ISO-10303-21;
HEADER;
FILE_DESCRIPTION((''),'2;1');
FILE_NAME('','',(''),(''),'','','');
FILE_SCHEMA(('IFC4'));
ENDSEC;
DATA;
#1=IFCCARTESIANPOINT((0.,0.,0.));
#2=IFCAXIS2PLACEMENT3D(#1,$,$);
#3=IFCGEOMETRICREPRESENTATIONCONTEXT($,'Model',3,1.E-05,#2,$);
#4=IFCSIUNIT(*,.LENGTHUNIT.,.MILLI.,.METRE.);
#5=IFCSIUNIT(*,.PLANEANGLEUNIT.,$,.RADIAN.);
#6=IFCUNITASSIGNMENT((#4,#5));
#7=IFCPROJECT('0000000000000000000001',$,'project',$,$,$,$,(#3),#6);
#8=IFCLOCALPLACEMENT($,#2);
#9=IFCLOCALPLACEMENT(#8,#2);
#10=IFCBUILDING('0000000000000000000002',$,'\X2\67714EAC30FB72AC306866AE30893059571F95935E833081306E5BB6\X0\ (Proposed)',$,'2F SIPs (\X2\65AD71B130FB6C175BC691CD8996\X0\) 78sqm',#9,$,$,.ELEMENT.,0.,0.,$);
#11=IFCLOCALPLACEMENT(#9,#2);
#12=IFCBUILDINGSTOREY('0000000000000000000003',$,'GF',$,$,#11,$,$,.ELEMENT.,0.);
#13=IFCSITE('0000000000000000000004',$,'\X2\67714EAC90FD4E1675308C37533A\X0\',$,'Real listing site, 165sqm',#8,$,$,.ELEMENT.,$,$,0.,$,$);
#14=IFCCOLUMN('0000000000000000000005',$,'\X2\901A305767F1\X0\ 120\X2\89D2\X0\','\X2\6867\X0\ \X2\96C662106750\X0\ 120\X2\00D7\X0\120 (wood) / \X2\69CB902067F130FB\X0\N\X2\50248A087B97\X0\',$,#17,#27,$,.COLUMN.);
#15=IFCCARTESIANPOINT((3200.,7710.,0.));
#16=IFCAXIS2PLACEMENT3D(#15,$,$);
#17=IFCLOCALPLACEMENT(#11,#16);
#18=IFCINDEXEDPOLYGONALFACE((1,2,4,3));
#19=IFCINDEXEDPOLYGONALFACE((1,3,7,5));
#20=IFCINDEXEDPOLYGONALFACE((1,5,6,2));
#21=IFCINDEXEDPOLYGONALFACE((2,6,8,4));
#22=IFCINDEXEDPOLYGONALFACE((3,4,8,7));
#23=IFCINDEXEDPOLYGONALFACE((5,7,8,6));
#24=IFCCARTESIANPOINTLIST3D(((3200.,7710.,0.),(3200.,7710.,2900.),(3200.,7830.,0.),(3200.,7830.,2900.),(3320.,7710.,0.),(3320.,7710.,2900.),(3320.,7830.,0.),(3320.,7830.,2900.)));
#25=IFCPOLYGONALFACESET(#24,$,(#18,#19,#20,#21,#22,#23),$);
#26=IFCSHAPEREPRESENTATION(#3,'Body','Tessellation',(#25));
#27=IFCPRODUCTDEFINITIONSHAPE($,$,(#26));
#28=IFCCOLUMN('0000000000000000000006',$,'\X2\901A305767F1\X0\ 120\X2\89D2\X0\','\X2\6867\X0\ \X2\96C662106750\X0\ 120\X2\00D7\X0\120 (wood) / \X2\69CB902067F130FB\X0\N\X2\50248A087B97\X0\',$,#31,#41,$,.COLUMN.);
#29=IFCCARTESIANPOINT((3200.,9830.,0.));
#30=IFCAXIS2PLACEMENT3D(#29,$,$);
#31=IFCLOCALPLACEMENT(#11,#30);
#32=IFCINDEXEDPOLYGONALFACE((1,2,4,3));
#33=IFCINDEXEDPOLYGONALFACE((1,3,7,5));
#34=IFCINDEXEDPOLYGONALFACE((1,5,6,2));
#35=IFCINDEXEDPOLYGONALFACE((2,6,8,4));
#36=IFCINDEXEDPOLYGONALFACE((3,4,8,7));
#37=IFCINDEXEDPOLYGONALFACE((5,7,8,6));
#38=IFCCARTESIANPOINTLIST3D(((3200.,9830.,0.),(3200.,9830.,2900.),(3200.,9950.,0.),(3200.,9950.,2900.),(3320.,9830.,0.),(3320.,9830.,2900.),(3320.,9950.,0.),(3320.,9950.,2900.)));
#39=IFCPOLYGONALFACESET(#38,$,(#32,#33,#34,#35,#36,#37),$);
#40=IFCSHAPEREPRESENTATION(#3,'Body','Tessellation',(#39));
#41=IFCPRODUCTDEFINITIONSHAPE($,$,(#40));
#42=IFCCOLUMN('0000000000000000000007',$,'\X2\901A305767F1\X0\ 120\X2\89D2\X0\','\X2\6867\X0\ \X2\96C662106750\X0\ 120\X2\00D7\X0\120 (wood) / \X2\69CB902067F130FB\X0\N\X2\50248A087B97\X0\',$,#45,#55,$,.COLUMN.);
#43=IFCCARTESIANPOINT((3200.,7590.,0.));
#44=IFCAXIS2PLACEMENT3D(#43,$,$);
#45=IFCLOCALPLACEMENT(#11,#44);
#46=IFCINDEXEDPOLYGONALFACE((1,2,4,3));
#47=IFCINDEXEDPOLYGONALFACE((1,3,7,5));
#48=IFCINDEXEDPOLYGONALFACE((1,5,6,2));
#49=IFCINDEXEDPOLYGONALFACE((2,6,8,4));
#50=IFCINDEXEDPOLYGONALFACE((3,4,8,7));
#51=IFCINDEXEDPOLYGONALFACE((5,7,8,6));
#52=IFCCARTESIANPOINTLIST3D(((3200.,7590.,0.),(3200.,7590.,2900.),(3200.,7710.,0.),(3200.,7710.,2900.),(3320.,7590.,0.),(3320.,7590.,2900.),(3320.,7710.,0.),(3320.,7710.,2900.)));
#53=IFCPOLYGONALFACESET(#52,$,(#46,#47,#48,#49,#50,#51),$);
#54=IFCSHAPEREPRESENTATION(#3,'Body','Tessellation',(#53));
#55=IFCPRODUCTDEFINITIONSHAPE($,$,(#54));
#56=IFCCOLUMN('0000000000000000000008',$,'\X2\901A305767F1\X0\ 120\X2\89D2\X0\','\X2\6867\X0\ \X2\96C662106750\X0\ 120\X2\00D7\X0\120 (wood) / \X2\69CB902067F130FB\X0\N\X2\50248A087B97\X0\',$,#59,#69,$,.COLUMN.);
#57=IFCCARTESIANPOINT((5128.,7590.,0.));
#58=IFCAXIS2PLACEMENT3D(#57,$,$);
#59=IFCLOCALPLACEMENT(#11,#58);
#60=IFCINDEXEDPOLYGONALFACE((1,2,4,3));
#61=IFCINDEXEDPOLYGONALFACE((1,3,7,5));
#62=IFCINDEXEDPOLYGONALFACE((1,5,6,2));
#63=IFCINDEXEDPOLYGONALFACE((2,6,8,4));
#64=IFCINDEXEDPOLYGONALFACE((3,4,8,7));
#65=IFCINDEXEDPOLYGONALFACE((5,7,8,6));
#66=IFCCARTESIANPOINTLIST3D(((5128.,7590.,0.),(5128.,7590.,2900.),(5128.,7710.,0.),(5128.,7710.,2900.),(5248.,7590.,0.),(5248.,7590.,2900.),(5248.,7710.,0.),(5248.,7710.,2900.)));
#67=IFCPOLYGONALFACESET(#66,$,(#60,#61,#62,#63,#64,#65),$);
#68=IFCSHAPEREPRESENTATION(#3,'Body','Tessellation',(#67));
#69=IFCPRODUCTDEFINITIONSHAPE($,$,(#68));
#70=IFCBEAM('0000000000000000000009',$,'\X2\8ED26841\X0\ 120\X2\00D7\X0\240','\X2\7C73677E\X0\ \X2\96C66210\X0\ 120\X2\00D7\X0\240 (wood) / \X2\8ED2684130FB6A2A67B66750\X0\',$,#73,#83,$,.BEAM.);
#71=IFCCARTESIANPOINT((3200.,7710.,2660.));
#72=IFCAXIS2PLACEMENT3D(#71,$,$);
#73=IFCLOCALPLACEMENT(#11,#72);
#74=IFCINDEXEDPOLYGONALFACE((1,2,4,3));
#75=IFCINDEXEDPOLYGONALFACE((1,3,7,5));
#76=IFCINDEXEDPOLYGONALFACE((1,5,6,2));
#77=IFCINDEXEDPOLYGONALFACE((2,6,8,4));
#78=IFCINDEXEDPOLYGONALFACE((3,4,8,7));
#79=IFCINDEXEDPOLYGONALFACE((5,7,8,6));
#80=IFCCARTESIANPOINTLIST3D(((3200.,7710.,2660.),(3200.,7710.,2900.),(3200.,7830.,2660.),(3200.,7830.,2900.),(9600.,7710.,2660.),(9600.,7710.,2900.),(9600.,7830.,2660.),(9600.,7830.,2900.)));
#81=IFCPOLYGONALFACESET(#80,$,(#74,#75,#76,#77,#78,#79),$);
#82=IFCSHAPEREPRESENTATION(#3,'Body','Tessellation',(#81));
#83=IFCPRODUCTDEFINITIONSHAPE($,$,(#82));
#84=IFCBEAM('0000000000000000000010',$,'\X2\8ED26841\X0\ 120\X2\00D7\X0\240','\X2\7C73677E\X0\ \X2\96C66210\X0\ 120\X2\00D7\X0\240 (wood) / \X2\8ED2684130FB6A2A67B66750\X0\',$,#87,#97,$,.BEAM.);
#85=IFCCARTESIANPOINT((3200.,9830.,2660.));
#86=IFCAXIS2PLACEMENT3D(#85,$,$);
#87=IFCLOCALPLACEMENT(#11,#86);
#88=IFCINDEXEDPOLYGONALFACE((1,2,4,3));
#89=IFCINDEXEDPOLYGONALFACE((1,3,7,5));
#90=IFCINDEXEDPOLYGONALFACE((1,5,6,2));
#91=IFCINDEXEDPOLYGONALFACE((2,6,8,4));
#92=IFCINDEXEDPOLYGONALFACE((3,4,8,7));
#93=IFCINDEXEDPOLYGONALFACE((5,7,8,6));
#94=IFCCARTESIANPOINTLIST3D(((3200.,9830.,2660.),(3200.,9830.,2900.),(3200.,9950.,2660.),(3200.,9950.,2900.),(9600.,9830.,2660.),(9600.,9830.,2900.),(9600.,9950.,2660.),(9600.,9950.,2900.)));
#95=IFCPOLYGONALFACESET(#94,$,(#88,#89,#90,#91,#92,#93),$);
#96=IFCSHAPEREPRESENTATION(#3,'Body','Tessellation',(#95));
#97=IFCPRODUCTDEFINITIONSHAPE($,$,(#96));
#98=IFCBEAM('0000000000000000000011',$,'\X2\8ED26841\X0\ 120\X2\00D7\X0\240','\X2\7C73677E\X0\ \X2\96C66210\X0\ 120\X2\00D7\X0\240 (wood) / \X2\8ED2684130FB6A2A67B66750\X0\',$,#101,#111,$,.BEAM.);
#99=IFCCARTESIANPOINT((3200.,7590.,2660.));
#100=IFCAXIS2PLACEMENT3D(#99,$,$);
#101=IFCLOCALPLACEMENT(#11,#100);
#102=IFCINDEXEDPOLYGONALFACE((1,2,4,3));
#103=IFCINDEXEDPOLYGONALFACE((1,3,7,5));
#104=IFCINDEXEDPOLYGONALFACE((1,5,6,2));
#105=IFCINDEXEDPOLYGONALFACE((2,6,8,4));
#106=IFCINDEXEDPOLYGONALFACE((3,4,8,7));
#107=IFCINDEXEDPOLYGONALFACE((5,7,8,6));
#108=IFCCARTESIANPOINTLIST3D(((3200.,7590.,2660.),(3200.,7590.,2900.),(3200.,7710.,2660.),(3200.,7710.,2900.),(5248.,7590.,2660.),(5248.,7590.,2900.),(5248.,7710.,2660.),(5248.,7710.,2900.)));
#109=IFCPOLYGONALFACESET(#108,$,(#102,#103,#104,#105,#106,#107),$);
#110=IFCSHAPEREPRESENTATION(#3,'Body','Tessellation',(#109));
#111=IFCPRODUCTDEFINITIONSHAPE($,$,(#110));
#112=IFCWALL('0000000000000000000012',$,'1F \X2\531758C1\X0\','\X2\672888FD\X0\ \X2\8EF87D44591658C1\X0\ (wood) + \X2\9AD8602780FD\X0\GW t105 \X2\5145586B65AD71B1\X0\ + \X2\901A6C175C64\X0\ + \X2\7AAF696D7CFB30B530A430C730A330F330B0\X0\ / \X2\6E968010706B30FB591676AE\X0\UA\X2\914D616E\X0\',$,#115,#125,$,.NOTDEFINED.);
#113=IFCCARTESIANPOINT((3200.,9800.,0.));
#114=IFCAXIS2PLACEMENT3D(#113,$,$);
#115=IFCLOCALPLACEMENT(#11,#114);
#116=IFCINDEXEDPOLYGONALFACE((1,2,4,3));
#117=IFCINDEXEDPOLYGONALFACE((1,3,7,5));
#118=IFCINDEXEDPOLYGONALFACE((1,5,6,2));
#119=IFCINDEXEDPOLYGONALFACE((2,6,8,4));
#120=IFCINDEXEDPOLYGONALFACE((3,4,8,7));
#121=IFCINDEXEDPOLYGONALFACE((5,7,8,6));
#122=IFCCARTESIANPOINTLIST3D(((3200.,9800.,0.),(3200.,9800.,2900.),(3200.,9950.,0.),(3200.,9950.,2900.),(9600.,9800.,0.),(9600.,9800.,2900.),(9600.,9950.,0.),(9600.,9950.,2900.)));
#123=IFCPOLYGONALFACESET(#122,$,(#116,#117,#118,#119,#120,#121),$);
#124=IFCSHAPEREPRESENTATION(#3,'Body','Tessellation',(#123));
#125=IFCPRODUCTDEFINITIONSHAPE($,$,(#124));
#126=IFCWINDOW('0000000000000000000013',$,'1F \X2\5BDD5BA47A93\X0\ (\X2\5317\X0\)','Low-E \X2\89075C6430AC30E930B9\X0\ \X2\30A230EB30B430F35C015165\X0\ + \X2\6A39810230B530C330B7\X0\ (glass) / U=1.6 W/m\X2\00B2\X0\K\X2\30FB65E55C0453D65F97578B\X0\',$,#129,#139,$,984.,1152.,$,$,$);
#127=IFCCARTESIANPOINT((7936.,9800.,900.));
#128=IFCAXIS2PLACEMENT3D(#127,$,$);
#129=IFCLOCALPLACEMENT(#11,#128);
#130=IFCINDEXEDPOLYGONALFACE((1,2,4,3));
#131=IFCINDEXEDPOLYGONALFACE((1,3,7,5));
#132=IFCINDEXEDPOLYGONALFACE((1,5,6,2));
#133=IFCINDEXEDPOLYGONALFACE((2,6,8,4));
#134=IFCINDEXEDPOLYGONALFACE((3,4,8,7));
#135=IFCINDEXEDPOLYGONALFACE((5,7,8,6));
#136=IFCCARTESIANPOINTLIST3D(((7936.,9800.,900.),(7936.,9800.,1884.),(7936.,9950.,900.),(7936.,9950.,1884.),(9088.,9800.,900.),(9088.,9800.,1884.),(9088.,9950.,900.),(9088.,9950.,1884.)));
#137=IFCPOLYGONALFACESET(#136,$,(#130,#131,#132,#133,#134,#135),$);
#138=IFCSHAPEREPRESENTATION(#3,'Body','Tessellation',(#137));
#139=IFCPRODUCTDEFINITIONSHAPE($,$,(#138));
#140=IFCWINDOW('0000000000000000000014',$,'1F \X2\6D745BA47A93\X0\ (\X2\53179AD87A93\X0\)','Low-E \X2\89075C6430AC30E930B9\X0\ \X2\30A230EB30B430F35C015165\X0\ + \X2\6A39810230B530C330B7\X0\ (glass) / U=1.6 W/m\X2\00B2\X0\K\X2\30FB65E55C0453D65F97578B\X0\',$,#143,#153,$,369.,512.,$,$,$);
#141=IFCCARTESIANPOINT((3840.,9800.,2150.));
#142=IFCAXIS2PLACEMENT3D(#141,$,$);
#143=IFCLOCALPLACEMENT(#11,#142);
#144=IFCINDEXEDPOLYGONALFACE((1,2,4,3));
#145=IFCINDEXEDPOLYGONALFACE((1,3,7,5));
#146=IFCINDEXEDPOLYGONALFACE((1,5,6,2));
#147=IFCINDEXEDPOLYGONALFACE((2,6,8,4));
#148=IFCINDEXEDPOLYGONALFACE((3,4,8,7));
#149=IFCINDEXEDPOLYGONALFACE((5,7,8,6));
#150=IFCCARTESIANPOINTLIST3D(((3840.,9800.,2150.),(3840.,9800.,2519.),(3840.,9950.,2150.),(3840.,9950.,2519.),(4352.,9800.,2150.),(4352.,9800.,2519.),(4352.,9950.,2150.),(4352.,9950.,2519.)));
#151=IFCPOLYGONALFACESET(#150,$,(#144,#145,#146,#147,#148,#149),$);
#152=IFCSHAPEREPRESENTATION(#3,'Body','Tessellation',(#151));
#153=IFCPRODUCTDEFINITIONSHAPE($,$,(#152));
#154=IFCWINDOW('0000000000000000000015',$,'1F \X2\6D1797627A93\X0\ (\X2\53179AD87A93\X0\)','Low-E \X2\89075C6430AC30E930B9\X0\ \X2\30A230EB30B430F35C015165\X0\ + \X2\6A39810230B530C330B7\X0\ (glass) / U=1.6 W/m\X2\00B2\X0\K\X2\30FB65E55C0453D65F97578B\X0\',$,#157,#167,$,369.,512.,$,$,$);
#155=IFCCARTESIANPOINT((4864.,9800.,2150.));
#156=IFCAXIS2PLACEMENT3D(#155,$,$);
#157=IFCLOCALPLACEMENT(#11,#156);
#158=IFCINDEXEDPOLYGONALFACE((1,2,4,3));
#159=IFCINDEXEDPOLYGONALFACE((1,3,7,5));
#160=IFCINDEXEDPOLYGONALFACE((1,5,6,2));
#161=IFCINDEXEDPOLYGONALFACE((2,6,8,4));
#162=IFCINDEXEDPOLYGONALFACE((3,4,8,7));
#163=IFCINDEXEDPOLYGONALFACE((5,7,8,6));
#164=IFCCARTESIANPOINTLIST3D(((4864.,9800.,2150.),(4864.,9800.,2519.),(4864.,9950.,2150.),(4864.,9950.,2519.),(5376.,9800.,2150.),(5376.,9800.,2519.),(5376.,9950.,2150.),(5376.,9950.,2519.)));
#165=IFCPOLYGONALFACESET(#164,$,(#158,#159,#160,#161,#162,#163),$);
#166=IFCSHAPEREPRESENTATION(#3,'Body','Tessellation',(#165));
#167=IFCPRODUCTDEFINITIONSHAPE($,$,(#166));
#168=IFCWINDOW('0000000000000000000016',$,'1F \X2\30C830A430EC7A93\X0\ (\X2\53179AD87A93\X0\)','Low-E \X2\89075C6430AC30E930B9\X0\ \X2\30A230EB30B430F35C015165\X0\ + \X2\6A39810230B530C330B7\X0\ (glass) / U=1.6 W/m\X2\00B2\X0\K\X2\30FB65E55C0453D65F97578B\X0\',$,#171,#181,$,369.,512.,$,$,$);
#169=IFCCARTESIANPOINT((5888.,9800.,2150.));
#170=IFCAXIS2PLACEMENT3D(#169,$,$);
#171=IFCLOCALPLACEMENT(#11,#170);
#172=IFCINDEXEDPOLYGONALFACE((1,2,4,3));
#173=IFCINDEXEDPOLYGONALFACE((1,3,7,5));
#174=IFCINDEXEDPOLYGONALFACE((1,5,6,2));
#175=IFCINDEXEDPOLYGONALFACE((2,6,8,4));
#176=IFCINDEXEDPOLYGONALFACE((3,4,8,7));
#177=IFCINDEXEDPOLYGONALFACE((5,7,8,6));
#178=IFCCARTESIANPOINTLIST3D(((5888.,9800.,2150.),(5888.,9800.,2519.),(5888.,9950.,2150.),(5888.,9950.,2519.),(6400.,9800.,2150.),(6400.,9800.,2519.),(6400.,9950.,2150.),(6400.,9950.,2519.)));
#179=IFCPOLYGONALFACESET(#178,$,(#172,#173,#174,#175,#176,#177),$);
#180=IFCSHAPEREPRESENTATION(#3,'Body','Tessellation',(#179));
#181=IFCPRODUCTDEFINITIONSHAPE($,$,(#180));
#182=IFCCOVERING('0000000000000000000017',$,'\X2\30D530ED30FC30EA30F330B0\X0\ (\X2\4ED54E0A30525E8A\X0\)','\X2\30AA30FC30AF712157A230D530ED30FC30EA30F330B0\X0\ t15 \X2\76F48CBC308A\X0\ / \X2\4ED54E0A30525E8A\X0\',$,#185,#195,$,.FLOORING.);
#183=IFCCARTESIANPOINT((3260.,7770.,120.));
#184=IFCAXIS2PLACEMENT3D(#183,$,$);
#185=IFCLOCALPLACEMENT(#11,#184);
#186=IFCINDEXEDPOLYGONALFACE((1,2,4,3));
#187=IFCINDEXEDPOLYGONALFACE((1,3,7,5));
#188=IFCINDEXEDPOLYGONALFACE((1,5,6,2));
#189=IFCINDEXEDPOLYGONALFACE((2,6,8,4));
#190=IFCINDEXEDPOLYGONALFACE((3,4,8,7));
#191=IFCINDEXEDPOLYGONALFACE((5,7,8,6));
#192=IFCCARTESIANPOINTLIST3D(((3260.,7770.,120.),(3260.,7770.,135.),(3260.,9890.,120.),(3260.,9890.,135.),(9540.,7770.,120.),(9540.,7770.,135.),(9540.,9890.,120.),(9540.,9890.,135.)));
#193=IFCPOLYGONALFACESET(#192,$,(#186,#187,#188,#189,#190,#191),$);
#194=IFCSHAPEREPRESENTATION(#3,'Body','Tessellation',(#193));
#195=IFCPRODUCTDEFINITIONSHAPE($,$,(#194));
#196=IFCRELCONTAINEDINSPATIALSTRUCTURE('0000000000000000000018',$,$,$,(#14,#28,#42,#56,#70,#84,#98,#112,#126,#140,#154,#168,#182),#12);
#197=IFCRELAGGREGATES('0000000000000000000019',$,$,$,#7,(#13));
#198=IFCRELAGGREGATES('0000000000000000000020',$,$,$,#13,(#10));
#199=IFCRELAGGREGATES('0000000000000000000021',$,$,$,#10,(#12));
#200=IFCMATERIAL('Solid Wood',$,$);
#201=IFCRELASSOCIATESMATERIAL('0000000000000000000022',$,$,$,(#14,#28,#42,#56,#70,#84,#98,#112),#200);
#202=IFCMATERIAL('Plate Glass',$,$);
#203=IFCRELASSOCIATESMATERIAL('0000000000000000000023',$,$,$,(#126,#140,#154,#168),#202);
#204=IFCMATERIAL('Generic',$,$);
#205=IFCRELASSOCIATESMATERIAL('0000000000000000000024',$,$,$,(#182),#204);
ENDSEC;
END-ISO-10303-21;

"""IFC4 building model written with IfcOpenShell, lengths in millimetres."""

from ifc_helpers import new_model, si_unit, frame, frame_2d, origin, place, context, project, spatial, rectangle, extrude, material, element, fill, save


model = new_model("IFC4")

# Units and contexts
model_context = context("Model", 3, precision=1e-05, world=origin())
ifc_project = project(units=[si_unit("LENGTHUNIT", "METRE", prefix="MILLI"), si_unit("PLANEANGLEUNIT", "RADIAN")], contexts=[model_context])

# Site, building, storey
site_placement = place(None, origin())
site = spatial("IfcSite", under=ifc_project, at=site_placement, Name="東京都世田谷区", ObjectType="Real listing site, 165sqm", CompositionType="ELEMENT", RefElevation=0.0)
building_placement = place(site_placement, origin())
building = spatial("IfcBuilding", under=site, at=building_placement, Name="東京・犬と暮らす土間広めの家 (Proposed)", ObjectType="2F SIPs (断熱・気密重視) 78sqm", CompositionType="ELEMENT", ElevationOfRefHeight=0.0, ElevationOfTerrain=0.0)
storey_placement = place(building_placement, origin())
storey = spatial("IfcBuildingStorey", under=building, at=storey_placement, Name="GF", CompositionType="ELEMENT", Elevation=0.0)

# Columns
ifc_material_1 = material(Name="Solid Wood")
column_1_placement = place(storey_placement, frame((3200.0, 7710.0, 0.0)))
element("IfcColumn", 1, at=column_1_placement, inside=storey, material=ifc_material_1, Name="通し柱 120角", Description="桧 集成材 120×120 (wood) / 構造柱・N値計算", PredefinedType="COLUMN", context=model_context, shape_type="SweptSolid", body=[
    extrude(rectangle(XDim=120.0, YDim=120.0, at=frame_2d((60.0, 60.0))), frame((3200.0, 7710.0, 0.0)), (0.0, 0.0, 1.0), 2900.0),
])
column_2_placement = place(storey_placement, frame((3200.0, 9830.0, 0.0)))
element("IfcColumn", 2, at=column_2_placement, inside=storey, material=ifc_material_1, Name="通し柱 120角", Description="桧 集成材 120×120 (wood) / 構造柱・N値計算", PredefinedType="COLUMN", context=model_context, shape_type="SweptSolid", body=[
    extrude(rectangle(XDim=120.0, YDim=120.0, at=frame_2d((60.0, 60.0))), frame((3200.0, 9830.0, 0.0)), (0.0, 0.0, 1.0), 2900.0),
])
column_3_placement = place(storey_placement, frame((3200.0, 7590.0, 0.0)))
element("IfcColumn", 3, at=column_3_placement, inside=storey, material=ifc_material_1, Name="通し柱 120角", Description="桧 集成材 120×120 (wood) / 構造柱・N値計算", PredefinedType="COLUMN", context=model_context, shape_type="SweptSolid", body=[
    extrude(rectangle(XDim=120.0, YDim=120.0, at=frame_2d((60.0, 60.0))), frame((3200.0, 7590.0, 0.0)), (0.0, 0.0, 1.0), 2900.0),
])
column_4_placement = place(storey_placement, frame((5128.0, 7590.0, 0.0)))
element("IfcColumn", 4, at=column_4_placement, inside=storey, material=ifc_material_1, Name="通し柱 120角", Description="桧 集成材 120×120 (wood) / 構造柱・N値計算", PredefinedType="COLUMN", context=model_context, shape_type="SweptSolid", body=[
    extrude(rectangle(XDim=120.0, YDim=120.0, at=frame_2d((60.0, 60.0))), frame((5128.0, 7590.0, 0.0)), (0.0, 0.0, 1.0), 2900.0),
])

# Beams
beam_1_placement = place(storey_placement, frame((3200.0, 7710.0, 2660.0)))
element("IfcBeam", 5, at=beam_1_placement, inside=storey, material=ifc_material_1, Name="軒桁 120×240", Description="米松 集成 120×240 (wood) / 軒桁・横架材", PredefinedType="BEAM", context=model_context, shape_type="SweptSolid", body=[
    extrude(rectangle(XDim=6400.0, YDim=120.0, at=frame_2d((3200.0, 60.0))), frame((3200.0, 7710.0, 2660.0)), (0.0, 0.0, 1.0), 240.0),
])
beam_2_placement = place(storey_placement, frame((3200.0, 9830.0, 2660.0)))
element("IfcBeam", 6, at=beam_2_placement, inside=storey, material=ifc_material_1, Name="軒桁 120×240", Description="米松 集成 120×240 (wood) / 軒桁・横架材", PredefinedType="BEAM", context=model_context, shape_type="SweptSolid", body=[
    extrude(rectangle(XDim=6400.0, YDim=120.0, at=frame_2d((3200.0, 60.0))), frame((3200.0, 9830.0, 2660.0)), (0.0, 0.0, 1.0), 240.0),
])
beam_3_placement = place(storey_placement, frame((3200.0, 7590.0, 2660.0)))
element("IfcBeam", 7, at=beam_3_placement, inside=storey, material=ifc_material_1, Name="軒桁 120×240", Description="米松 集成 120×240 (wood) / 軒桁・横架材", PredefinedType="BEAM", context=model_context, shape_type="SweptSolid", body=[
    extrude(rectangle(XDim=2048.0, YDim=120.0, at=frame_2d((1024.0, 60.0))), frame((3200.0, 7590.0, 2660.0)), (0.0, 0.0, 1.0), 240.0),
])

# Wall, openings, windows
wall_1_placement = place(storey_placement, frame((3200.0, 9800.0, 0.0)))
wall_1 = element("IfcWall", 8, at=wall_1_placement, inside=storey, material=ifc_material_1, Name="1F 北壁", Description="木製 軸組外壁 (wood) + 高性能GW t105 充填断熱 + 通気層 + 窯業系サイディング / 準耐火・外皮UA配慮", PredefinedType="NOTDEFINED", context=model_context, shape_type="SweptSolid", body=[
    extrude(rectangle(XDim=6400.0, YDim=150.0, at=frame_2d((3200.0, 75.0))), frame((3200.0, 9800.0, 0.0)), (0.0, 0.0, 1.0), 2900.0),
])
opening_1_placement = place(storey_placement, frame((7936.0, 9800.0, 900.0)))
opening_1 = element("IfcOpeningElement", 9, at=opening_1_placement, cuts=wall_1, PredefinedType="NOTDEFINED", context=model_context, shape_type="SweptSolid", body=[
    extrude(rectangle(XDim=1152.0, YDim=150.0, at=frame_2d((576.0, 75.0))), frame((7936.0, 9800.0, 900.0)), (0.0, 0.0, 1.0), 984.0),
])
opening_2_placement = place(storey_placement, frame((3840.0, 9800.0, 2150.0)))
opening_2 = element("IfcOpeningElement", 10, at=opening_2_placement, cuts=wall_1, PredefinedType="NOTDEFINED", context=model_context, shape_type="SweptSolid", body=[
    extrude(rectangle(XDim=512.0, YDim=150.0, at=frame_2d((256.0, 75.0))), frame((3840.0, 9800.0, 2150.0)), (0.0, 0.0, 1.0), 369.0),
])
opening_3_placement = place(storey_placement, frame((4864.0, 9800.0, 2150.0)))
opening_3 = element("IfcOpeningElement", 11, at=opening_3_placement, cuts=wall_1, PredefinedType="NOTDEFINED", context=model_context, shape_type="SweptSolid", body=[
    extrude(rectangle(XDim=512.0, YDim=150.0, at=frame_2d((256.0, 75.0))), frame((4864.0, 9800.0, 2150.0)), (0.0, 0.0, 1.0), 369.0),
])
opening_4_placement = place(storey_placement, frame((5888.0, 9800.0, 2150.0)))
opening_4 = element("IfcOpeningElement", 12, at=opening_4_placement, cuts=wall_1, PredefinedType="NOTDEFINED", context=model_context, shape_type="SweptSolid", body=[
    extrude(rectangle(XDim=512.0, YDim=150.0, at=frame_2d((256.0, 75.0))), frame((5888.0, 9800.0, 2150.0)), (0.0, 0.0, 1.0), 369.0),
])
ifc_material_2 = material(Name="Plate Glass")
window_1_placement = place(storey_placement, frame((7936.0, 9800.0, 900.0)))
window_1 = element("IfcWindow", 13, at=window_1_placement, inside=storey, material=ifc_material_2, Name="1F 寝室窓 (北)", Description="Low-E 複層ガラス アルゴン封入 + 樹脂サッシ (glass) / U=1.6 W/m²K・日射取得型", OverallHeight=984.0, OverallWidth=1152.0, context=model_context, shape_type="SweptSolid", body=[
    extrude(rectangle(XDim=1152.0, YDim=150.0, at=frame_2d((576.0, 75.0))), frame((7936.0, 9800.0, 900.0)), (0.0, 0.0, 1.0), 984.0),
])
fill(opening_1, window_1)
window_2_placement = place(storey_placement, frame((3840.0, 9800.0, 2150.0)))
window_2 = element("IfcWindow", 14, at=window_2_placement, inside=storey, material=ifc_material_2, Name="1F 浴室窓 (北高窓)", Description="Low-E 複層ガラス アルゴン封入 + 樹脂サッシ (glass) / U=1.6 W/m²K・日射取得型", OverallHeight=369.0, OverallWidth=512.0, context=model_context, shape_type="SweptSolid", body=[
    extrude(rectangle(XDim=512.0, YDim=150.0, at=frame_2d((256.0, 75.0))), frame((3840.0, 9800.0, 2150.0)), (0.0, 0.0, 1.0), 369.0),
])
fill(opening_2, window_2)
window_3_placement = place(storey_placement, frame((4864.0, 9800.0, 2150.0)))
window_3 = element("IfcWindow", 15, at=window_3_placement, inside=storey, material=ifc_material_2, Name="1F 洗面窓 (北高窓)", Description="Low-E 複層ガラス アルゴン封入 + 樹脂サッシ (glass) / U=1.6 W/m²K・日射取得型", OverallHeight=369.0, OverallWidth=512.0, context=model_context, shape_type="SweptSolid", body=[
    extrude(rectangle(XDim=512.0, YDim=150.0, at=frame_2d((256.0, 75.0))), frame((4864.0, 9800.0, 2150.0)), (0.0, 0.0, 1.0), 369.0),
])
fill(opening_3, window_3)
window_4_placement = place(storey_placement, frame((5888.0, 9800.0, 2150.0)))
window_4 = element("IfcWindow", 16, at=window_4_placement, inside=storey, material=ifc_material_2, Name="1F トイレ窓 (北高窓)", Description="Low-E 複層ガラス アルゴン封入 + 樹脂サッシ (glass) / U=1.6 W/m²K・日射取得型", OverallHeight=369.0, OverallWidth=512.0, context=model_context, shape_type="SweptSolid", body=[
    extrude(rectangle(XDim=512.0, YDim=150.0, at=frame_2d((256.0, 75.0))), frame((5888.0, 9800.0, 2150.0)), (0.0, 0.0, 1.0), 369.0),
])
fill(opening_4, window_4)

# Covering
ifc_material_3 = material(Name="Generic")
covering_1_placement = place(storey_placement, frame((3260.0, 7770.0, 120.0)))
element("IfcCovering", 17, at=covering_1_placement, inside=storey, material=ifc_material_3, Name="フローリング (仕上げ床)", Description="オーク無垢フローリング t15 直貼り / 仕上げ床", PredefinedType="FLOORING", context=model_context, shape_type="SweptSolid", body=[
    extrude(rectangle(XDim=6280.0, YDim=2120.0, at=frame_2d((3140.0, 1060.0))), frame((3260.0, 7770.0, 120.0)), (0.0, 0.0, 1.0), 15.0),
])

save(model, "model.ifc")
